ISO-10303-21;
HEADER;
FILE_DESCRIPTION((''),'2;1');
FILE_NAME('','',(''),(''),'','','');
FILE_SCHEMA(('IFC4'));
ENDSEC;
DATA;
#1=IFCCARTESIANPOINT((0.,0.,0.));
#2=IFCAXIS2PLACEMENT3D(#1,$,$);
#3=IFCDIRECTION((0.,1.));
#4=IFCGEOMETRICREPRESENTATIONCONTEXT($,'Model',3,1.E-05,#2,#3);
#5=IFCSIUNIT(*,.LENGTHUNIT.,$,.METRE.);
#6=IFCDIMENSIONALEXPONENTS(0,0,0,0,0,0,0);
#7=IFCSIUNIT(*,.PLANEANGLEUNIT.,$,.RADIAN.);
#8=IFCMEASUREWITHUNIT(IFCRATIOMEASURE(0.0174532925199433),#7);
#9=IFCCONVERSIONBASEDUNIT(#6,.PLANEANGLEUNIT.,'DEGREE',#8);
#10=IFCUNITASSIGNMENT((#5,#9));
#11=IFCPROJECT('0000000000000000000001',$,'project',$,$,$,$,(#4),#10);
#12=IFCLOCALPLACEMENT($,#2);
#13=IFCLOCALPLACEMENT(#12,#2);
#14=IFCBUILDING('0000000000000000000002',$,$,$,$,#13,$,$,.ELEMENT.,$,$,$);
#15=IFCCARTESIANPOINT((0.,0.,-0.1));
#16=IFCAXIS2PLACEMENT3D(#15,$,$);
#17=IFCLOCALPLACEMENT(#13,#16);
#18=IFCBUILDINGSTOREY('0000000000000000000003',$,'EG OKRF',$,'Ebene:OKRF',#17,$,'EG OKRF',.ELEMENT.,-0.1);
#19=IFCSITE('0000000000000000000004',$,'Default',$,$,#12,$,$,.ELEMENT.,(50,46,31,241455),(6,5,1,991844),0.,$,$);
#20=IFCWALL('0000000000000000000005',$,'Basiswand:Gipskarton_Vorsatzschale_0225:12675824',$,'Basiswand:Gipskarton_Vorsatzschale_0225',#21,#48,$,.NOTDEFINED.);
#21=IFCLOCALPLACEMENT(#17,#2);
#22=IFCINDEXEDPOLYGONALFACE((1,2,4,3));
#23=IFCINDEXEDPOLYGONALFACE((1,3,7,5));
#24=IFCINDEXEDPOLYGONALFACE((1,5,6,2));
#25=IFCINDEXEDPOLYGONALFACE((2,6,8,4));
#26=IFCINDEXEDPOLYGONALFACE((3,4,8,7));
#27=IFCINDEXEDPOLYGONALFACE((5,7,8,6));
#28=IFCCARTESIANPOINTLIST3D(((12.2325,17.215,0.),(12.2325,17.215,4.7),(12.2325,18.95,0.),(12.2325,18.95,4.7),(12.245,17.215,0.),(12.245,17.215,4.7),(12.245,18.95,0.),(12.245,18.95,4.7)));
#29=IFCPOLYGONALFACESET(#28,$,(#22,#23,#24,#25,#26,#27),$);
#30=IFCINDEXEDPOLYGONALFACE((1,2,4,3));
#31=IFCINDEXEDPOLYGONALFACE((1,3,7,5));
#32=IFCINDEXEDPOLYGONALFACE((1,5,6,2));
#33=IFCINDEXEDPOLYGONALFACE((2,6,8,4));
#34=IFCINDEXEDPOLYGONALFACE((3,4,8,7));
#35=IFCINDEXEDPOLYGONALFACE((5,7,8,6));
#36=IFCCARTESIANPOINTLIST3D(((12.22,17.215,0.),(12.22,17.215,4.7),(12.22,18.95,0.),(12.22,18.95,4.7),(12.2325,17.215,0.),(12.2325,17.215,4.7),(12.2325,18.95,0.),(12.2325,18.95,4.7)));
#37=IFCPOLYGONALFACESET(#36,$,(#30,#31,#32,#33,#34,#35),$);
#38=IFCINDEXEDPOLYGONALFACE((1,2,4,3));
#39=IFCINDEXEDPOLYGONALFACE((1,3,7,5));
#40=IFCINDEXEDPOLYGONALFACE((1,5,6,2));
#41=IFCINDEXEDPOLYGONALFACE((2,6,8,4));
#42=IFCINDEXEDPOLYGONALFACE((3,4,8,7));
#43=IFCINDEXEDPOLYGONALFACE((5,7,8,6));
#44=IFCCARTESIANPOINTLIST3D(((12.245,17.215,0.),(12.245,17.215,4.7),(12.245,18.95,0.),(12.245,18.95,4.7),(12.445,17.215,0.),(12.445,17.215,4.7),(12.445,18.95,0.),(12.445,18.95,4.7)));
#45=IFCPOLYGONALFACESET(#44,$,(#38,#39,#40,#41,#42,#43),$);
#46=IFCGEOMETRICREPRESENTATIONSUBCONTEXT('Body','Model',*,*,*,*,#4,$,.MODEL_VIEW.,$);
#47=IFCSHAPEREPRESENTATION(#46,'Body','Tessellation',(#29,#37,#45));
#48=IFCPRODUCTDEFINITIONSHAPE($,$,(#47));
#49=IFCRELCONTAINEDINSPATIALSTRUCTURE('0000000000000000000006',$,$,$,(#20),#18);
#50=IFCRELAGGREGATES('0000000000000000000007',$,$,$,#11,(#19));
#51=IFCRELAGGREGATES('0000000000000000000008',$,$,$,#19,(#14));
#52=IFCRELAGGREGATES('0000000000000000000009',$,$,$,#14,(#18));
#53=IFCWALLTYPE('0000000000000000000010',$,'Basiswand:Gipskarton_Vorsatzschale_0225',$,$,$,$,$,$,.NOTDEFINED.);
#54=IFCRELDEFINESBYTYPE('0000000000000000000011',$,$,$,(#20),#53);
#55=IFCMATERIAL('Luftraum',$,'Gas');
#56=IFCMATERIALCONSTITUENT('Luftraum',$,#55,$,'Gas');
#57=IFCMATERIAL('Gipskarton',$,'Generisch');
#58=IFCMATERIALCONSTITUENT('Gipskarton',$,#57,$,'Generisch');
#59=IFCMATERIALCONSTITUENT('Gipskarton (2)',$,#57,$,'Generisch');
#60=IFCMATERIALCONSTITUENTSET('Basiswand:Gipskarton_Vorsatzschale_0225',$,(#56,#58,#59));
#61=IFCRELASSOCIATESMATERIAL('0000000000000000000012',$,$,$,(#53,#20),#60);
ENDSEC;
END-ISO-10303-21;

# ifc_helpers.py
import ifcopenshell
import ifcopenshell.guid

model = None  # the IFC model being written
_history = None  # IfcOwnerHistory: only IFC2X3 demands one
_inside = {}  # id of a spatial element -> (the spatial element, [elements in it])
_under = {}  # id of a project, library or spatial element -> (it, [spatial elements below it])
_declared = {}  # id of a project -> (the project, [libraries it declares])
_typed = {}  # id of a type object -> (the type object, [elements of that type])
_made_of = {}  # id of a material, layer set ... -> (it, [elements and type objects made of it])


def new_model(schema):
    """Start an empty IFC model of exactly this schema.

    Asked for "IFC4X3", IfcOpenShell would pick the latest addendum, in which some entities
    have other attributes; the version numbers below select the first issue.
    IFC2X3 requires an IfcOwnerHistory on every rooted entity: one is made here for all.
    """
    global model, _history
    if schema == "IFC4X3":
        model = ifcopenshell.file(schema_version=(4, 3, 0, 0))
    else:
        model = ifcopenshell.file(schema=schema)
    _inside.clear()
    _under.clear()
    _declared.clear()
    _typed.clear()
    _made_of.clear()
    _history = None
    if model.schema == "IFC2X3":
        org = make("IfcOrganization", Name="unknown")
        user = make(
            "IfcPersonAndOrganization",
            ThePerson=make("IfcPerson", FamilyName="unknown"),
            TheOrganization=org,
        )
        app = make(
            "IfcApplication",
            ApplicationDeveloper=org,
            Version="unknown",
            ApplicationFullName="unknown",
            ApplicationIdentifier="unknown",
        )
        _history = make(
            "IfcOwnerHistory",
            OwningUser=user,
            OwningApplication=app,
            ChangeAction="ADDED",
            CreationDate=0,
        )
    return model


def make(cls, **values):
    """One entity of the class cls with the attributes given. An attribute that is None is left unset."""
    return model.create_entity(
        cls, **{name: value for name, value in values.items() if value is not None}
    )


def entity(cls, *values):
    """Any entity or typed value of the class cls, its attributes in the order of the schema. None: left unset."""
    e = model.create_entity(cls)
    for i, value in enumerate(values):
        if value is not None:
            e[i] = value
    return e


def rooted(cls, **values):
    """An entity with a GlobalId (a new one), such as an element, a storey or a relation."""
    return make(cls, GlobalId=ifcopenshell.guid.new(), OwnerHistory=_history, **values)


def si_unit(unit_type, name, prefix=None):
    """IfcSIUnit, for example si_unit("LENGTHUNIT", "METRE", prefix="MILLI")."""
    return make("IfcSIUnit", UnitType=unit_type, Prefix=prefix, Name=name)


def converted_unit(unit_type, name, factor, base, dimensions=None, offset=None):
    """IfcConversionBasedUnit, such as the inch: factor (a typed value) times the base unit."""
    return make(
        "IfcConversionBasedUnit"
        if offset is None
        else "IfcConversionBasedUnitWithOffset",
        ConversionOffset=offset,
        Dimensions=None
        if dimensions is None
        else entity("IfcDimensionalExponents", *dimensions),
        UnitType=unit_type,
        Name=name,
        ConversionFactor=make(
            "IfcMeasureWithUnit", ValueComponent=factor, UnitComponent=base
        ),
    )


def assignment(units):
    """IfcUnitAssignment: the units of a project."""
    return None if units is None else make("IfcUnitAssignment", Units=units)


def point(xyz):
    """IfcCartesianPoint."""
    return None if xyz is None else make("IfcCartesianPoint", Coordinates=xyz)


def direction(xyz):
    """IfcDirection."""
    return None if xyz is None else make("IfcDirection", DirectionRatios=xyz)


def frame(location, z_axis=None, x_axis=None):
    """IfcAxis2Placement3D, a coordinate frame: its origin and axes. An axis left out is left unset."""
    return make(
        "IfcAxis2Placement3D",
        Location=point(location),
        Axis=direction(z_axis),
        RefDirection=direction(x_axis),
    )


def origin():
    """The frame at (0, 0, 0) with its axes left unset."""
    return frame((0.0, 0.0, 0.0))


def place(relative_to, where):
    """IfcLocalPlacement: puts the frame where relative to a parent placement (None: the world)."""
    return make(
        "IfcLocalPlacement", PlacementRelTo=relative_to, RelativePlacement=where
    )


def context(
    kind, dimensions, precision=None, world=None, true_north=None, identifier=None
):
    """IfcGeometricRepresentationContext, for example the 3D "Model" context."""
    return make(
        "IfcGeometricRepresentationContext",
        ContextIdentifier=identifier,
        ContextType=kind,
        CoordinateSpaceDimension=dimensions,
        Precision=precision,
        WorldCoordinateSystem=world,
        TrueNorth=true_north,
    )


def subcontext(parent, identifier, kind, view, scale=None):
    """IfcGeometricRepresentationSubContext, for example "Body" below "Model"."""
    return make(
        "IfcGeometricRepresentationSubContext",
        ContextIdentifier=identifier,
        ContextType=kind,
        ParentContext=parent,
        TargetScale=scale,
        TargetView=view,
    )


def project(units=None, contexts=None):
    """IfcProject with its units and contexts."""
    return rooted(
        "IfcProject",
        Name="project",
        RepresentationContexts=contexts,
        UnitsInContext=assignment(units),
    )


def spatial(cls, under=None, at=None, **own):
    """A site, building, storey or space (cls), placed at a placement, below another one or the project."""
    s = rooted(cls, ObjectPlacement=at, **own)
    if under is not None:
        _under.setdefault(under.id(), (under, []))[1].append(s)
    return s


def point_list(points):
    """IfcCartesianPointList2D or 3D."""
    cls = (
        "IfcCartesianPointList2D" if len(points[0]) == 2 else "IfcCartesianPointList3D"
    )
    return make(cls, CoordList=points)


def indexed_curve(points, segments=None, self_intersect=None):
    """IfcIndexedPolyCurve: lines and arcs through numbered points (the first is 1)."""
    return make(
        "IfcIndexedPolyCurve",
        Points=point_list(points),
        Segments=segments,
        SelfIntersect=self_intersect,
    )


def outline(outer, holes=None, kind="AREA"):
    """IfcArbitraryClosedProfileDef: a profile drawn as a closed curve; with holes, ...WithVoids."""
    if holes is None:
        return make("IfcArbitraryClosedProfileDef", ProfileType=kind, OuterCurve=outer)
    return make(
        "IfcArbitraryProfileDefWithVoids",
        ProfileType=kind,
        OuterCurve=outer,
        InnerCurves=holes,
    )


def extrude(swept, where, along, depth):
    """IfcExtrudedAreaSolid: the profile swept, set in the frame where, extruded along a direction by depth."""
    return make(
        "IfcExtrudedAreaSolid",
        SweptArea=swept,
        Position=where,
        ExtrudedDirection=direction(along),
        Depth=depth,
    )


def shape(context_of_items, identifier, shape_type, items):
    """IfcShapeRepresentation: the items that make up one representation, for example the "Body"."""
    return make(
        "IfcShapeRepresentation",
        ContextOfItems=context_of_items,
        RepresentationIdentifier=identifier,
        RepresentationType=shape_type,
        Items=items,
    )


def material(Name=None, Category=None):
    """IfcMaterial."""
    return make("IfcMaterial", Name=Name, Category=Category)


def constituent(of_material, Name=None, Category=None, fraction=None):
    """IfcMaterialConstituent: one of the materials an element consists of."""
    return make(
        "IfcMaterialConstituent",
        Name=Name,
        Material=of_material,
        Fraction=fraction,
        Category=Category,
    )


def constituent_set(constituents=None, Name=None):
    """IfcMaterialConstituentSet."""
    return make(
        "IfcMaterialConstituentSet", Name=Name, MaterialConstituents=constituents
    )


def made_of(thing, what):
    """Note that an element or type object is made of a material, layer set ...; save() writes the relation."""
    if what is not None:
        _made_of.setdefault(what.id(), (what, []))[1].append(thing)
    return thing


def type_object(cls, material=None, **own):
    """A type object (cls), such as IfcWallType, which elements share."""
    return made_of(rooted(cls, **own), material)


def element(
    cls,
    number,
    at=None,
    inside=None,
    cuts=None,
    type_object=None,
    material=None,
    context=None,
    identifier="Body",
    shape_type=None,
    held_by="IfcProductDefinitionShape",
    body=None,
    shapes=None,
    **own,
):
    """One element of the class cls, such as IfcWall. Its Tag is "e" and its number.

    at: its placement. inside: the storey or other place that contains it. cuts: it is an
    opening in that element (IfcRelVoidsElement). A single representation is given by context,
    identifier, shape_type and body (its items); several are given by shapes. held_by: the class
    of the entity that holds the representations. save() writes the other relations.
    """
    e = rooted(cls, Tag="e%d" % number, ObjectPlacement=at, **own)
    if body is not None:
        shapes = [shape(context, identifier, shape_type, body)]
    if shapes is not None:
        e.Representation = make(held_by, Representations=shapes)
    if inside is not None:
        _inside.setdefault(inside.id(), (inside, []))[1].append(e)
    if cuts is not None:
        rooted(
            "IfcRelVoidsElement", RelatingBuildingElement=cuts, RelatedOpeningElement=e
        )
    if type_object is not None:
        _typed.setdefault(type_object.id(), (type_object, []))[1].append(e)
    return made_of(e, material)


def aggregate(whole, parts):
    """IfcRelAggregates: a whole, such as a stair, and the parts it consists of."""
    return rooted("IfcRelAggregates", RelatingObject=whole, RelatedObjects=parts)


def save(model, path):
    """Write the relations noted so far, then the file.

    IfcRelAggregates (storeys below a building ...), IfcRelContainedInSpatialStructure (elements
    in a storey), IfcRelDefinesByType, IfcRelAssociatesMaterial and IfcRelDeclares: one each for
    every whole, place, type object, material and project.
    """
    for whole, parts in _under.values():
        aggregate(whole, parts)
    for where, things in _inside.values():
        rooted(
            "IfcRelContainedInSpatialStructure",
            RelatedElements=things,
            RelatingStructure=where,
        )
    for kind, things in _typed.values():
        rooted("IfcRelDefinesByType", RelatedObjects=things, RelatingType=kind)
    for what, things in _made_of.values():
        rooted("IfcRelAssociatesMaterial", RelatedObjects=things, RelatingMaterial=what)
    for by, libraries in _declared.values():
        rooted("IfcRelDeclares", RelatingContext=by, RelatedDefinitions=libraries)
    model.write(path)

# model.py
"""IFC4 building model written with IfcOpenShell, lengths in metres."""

from ifc_helpers import new_model, entity, si_unit, converted_unit, direction, frame, origin, place, context, subcontext, project, spatial, indexed_curve, outline, extrude, material, constituent, constituent_set, type_object, element, save


model = new_model("IFC4")

# Units and contexts
model_context = context("Model", 3, precision=1e-05, world=origin(), true_north=direction((0.0, 1.0)))
body_context = subcontext(model_context, "Body", "Model", "MODEL_VIEW")
ifc_project = project(units=[si_unit("LENGTHUNIT", "METRE"), converted_unit("PLANEANGLEUNIT", "DEGREE", entity("IfcRatioMeasure", 0.0174532925199433), si_unit("PLANEANGLEUNIT", "RADIAN"), dimensions=[0, 0, 0, 0, 0, 0, 0])], contexts=[model_context])

# Site, building, storey
site_placement = place(None, origin())
site = spatial("IfcSite", under=ifc_project, at=site_placement, Name="Default", CompositionType="ELEMENT", RefLatitude=(50, 46, 31, 241455), RefLongitude=(6, 5, 1, 991844), RefElevation=0.0)
building_placement = place(site_placement, origin())
building = spatial("IfcBuilding", under=site, at=building_placement, CompositionType="ELEMENT")
storey_placement = place(building_placement, frame((0.0, 0.0, -0.1)))
storey = spatial("IfcBuildingStorey", under=building, at=storey_placement, Name="EG OKRF", ObjectType="Ebene:OKRF", LongName="EG OKRF", CompositionType="ELEMENT", Elevation=-0.1)

# Shared definitions
ifc_material_1 = material(Name="Gipskarton", Category="Generisch")

# Wall
ifc_material_2 = material(Name="Luftraum", Category="Gas")
ifc_constituent_1 = constituent(ifc_material_2, Name="Luftraum", Category="Gas")
ifc_constituent_2 = constituent(ifc_material_1, Name="Gipskarton", Category="Generisch")
ifc_constituent_3 = constituent(ifc_material_1, Name="Gipskarton (2)", Category="Generisch")
ifc_constituent_set_1 = constituent_set(constituents=[ifc_constituent_1, ifc_constituent_2, ifc_constituent_3], Name="Basiswand:Gipskarton_Vorsatzschale_0225")
wall_type_1 = type_object("IfcWallType", Name="Basiswand:Gipskarton_Vorsatzschale_0225", PredefinedType="NOTDEFINED", material=ifc_constituent_set_1)
wall_1_placement = place(storey_placement, frame((12.3325, 18.95, 0.0), z_axis=(0.0, 0.0, 1.0), x_axis=(0.0, -1.0, 0.0)))
element("IfcWall", 1, at=wall_1_placement, inside=storey, type_object=wall_type_1, material=ifc_constituent_set_1, Name="Basiswand:Gipskarton_Vorsatzschale_0225:12675824", ObjectType="Basiswand:Gipskarton_Vorsatzschale_0225", PredefinedType="NOTDEFINED", context=body_context, shape_type="SweptSolid", body=[
    extrude(outline(indexed_curve([(-0.8675, -0.0063), (0.8675, -0.0063), (0.8675, 0.0062), (-0.8675, 0.0062), (-0.8675, -0.0063)], self_intersect=False)), frame((0.8675, -0.0937, 0.0)), (0.0, 0.0, 1.0), 4.7),
    extrude(outline(indexed_curve([(-0.0063, -0.8675), (0.0062, -0.8675), (0.0063, 0.8675), (-0.0062, 0.8675), (-0.0063, -0.8675)], self_intersect=False)), frame((0.8675, -0.1063, 0.0), z_axis=(0.0, 0.0, 1.0), x_axis=(0.0, 1.0, 0.0)), (0.0, 0.0, 1.0), 4.7),
    extrude(outline(indexed_curve([(-0.1, -0.8675), (0.1, -0.8675), (0.1, 0.8675), (-0.1, 0.8675), (-0.1, -0.8675)], self_intersect=False)), frame((0.8675, 0.0125, 0.0), z_axis=(0.0, 0.0, 1.0), x_axis=(0.0, -1.0, 0.0)), (0.0, 0.0, 1.0), 4.7),
])

save(model, "model.ifc")
